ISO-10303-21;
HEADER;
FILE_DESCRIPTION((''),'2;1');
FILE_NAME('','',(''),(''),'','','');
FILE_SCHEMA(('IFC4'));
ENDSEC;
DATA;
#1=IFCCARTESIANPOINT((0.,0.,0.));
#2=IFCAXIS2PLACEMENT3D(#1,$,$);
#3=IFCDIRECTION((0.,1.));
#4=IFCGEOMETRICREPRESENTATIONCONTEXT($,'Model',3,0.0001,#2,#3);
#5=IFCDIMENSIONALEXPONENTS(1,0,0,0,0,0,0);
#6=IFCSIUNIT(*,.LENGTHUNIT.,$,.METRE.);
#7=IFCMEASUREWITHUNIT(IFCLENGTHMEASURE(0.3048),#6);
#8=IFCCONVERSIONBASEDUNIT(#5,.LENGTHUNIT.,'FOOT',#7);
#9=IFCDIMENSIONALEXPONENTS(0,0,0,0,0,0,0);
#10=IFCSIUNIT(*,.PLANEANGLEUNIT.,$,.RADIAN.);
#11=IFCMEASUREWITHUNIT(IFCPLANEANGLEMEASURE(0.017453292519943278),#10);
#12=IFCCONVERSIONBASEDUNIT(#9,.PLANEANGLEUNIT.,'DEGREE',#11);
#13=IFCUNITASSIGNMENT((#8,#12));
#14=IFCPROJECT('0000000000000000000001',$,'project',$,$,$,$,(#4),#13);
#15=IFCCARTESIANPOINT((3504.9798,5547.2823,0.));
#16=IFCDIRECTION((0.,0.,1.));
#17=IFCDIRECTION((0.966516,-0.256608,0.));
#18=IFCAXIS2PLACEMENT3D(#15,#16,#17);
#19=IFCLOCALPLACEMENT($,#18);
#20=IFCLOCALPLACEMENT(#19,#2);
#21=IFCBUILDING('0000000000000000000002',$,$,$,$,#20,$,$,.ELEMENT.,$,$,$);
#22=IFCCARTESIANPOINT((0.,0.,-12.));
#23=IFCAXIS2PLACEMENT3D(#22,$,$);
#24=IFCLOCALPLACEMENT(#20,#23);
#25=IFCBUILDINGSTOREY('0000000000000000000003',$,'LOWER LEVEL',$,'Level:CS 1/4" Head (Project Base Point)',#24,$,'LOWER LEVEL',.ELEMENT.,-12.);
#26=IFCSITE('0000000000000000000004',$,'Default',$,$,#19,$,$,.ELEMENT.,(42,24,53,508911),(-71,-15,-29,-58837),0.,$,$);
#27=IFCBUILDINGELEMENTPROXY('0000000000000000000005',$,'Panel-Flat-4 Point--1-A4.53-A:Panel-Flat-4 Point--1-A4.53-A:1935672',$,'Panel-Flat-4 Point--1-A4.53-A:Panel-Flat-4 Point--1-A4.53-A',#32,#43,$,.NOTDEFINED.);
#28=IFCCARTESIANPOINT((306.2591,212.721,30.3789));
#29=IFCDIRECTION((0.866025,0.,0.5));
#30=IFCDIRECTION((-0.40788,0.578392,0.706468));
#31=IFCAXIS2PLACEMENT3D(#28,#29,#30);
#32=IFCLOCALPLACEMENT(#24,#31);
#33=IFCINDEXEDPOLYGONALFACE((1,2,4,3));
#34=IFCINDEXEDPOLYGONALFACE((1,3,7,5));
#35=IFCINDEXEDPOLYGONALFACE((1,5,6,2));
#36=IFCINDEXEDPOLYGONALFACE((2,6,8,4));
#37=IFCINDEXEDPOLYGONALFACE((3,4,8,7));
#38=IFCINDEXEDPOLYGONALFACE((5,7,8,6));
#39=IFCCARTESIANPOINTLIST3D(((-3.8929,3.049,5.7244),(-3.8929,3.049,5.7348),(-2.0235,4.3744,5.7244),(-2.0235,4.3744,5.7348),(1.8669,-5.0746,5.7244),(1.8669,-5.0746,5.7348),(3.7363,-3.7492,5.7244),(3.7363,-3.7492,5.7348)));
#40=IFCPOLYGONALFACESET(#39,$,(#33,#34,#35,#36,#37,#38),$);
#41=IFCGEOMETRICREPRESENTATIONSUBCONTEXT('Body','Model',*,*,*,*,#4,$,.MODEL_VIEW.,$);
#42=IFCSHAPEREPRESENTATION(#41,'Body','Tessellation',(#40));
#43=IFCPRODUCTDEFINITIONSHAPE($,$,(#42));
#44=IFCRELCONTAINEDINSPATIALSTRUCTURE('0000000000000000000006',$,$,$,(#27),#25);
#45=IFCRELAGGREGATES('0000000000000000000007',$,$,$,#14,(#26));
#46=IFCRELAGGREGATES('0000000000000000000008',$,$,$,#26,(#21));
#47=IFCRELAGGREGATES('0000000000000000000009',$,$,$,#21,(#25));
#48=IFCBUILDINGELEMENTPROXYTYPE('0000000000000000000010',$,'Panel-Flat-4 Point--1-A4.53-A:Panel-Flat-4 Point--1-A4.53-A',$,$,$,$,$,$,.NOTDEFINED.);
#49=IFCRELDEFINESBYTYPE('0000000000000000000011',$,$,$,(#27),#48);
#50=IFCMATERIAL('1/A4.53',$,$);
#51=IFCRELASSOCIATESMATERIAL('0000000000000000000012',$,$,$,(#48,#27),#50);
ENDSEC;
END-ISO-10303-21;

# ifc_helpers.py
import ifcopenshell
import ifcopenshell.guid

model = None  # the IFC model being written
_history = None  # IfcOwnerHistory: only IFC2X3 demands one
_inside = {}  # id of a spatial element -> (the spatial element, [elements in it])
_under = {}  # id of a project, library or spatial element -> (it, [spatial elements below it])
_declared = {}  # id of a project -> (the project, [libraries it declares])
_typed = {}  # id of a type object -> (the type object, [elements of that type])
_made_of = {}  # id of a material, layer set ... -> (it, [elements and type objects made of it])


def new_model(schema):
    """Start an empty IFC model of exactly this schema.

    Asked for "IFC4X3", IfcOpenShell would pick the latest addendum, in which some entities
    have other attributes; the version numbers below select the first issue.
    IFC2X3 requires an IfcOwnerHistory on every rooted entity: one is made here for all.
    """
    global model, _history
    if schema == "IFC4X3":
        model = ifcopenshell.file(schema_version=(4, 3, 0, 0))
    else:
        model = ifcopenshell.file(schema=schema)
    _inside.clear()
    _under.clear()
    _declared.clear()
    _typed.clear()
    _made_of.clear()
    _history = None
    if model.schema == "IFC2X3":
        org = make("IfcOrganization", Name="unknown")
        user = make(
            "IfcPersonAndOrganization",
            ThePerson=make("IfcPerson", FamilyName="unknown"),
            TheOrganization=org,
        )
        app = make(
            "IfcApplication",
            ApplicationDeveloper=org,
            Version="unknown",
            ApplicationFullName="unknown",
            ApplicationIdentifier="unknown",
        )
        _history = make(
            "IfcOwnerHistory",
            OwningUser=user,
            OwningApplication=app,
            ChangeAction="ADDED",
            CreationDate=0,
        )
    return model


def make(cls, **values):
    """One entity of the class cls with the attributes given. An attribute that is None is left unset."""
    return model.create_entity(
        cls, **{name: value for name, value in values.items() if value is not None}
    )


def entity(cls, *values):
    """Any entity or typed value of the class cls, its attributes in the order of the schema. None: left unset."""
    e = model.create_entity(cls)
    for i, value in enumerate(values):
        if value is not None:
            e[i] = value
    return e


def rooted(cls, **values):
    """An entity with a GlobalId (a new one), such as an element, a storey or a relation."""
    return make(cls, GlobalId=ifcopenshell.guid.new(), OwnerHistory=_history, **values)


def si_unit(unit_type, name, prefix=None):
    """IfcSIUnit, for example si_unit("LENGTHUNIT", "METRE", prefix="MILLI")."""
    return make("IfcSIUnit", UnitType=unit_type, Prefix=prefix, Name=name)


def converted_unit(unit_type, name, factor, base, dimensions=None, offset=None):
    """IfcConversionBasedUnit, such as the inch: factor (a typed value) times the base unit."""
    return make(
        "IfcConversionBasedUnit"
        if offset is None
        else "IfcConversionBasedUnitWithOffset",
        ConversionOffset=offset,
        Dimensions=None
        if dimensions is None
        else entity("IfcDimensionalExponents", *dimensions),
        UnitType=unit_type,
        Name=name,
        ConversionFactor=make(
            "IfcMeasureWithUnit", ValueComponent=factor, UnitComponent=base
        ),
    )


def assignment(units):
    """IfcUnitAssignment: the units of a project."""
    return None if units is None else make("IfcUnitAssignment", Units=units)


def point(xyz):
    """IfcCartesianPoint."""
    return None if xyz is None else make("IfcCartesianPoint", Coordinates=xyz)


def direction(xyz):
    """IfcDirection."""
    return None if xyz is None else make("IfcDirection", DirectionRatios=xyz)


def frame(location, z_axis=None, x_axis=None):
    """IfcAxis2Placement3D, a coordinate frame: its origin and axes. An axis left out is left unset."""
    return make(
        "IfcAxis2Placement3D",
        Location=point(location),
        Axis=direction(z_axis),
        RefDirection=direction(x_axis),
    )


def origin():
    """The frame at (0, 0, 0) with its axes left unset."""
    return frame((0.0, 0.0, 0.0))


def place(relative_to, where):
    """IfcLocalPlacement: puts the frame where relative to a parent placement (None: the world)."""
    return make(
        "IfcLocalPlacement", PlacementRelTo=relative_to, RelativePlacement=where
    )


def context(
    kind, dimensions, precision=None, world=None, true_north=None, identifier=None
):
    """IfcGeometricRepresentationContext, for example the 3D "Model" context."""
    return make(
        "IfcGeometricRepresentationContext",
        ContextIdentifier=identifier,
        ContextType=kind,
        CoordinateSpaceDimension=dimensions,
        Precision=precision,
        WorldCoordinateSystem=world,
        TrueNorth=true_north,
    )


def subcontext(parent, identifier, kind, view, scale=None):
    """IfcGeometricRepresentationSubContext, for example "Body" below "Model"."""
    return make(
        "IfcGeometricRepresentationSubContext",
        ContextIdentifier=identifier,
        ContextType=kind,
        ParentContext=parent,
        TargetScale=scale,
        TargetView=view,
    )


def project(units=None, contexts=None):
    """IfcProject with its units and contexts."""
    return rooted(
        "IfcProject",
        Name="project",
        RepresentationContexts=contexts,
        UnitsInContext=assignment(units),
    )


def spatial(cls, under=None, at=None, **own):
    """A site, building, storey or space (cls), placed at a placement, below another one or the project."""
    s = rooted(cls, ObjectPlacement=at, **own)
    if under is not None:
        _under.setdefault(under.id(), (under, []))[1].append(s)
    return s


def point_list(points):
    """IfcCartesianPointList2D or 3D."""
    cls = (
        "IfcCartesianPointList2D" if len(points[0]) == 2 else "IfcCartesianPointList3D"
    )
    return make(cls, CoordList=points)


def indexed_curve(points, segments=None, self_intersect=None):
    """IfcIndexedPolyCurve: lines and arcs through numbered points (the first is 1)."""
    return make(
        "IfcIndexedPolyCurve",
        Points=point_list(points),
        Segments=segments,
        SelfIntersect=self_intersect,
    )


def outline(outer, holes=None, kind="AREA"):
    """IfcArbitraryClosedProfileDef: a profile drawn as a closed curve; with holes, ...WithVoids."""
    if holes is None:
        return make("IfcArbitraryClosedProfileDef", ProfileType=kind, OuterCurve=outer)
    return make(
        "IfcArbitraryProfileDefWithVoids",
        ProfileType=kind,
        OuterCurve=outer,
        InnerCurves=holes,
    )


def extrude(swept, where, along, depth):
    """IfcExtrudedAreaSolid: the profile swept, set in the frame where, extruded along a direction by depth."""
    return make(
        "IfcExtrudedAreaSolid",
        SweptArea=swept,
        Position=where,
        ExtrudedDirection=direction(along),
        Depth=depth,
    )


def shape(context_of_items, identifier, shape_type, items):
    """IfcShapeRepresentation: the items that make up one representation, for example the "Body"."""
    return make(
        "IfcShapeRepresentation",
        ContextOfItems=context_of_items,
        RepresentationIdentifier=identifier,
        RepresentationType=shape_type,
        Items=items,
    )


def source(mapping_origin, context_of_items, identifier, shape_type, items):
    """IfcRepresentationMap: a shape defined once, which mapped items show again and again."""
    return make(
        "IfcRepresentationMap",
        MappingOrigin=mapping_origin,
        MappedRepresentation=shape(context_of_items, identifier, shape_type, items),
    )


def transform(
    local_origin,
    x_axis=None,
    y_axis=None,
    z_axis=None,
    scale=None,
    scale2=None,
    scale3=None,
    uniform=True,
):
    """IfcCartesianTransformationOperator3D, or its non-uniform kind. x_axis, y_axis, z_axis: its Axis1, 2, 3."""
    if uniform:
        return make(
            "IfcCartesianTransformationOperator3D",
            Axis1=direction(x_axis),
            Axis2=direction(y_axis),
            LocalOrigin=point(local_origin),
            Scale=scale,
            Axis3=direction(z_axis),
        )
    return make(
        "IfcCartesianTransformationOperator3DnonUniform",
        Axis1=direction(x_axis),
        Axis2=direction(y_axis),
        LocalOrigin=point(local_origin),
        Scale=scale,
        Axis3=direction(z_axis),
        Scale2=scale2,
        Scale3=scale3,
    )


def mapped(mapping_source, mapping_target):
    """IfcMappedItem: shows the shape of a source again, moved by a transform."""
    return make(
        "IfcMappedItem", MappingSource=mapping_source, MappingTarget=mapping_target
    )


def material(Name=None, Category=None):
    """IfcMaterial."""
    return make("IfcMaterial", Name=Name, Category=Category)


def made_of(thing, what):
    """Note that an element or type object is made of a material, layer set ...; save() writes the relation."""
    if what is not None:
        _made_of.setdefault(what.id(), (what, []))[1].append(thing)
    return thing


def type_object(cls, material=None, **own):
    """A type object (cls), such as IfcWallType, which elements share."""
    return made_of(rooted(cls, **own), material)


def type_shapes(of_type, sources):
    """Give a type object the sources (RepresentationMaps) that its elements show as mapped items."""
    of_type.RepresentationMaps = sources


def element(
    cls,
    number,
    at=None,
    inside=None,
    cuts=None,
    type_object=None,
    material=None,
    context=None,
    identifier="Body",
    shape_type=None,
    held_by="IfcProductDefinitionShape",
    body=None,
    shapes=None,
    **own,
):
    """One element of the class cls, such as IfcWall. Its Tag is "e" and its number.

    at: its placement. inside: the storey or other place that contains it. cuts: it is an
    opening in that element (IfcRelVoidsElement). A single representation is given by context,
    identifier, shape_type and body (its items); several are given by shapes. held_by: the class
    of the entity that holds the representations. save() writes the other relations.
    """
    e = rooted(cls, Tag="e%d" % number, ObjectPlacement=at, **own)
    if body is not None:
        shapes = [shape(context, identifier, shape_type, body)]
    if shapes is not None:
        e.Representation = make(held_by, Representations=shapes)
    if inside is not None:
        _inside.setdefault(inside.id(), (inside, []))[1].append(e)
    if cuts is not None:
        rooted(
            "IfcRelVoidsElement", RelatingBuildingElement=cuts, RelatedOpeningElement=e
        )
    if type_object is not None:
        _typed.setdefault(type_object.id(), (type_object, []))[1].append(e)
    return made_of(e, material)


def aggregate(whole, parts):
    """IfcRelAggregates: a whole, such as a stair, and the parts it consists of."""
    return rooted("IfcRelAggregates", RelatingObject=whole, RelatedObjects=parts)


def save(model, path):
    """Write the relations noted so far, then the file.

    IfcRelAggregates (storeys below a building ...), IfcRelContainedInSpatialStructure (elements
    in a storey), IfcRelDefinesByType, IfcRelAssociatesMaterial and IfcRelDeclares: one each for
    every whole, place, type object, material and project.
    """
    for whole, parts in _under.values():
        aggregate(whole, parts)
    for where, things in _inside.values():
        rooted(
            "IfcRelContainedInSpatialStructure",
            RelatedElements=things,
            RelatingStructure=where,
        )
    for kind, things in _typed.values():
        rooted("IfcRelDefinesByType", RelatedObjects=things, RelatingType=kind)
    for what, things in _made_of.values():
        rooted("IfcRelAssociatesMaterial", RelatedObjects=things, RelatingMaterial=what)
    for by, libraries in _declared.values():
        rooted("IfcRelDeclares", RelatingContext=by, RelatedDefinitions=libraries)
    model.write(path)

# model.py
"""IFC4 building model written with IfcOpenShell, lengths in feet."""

from ifc_helpers import new_model, entity, si_unit, converted_unit, direction, frame, origin, place, context, subcontext, project, spatial, indexed_curve, outline, extrude, source, transform, mapped, material, type_object, type_shapes, element, save


model = new_model("IFC4")

# Units and contexts
model_context = context("Model", 3, precision=0.0001, world=origin(), true_north=direction((0.0, 1.0)))
body_context = subcontext(model_context, "Body", "Model", "MODEL_VIEW")
ifc_project = project(units=[converted_unit("LENGTHUNIT", "FOOT", entity("IfcLengthMeasure", 0.3048), si_unit("LENGTHUNIT", "METRE"), dimensions=[1, 0, 0, 0, 0, 0, 0]), converted_unit("PLANEANGLEUNIT", "DEGREE", entity("IfcPlaneAngleMeasure", 0.017453292519943278), si_unit("PLANEANGLEUNIT", "RADIAN"), dimensions=[0, 0, 0, 0, 0, 0, 0])], contexts=[model_context])

# Site, building, storey
site_placement = place(None, frame((3504.9798, 5547.2823, 0.0), z_axis=(0.0, 0.0, 1.0), x_axis=(0.966516, -0.256608, 0.0)))
site = spatial("IfcSite", under=ifc_project, at=site_placement, Name="Default", CompositionType="ELEMENT", RefLatitude=(42, 24, 53, 508911), RefLongitude=(-71, -15, -29, -58837), RefElevation=0.0)
building_placement = place(site_placement, origin())
building = spatial("IfcBuilding", under=site, at=building_placement, CompositionType="ELEMENT")
storey_placement = place(building_placement, frame((0.0, 0.0, -12.0)))
storey = spatial("IfcBuildingStorey", under=building, at=storey_placement, Name="LOWER LEVEL", ObjectType="Level:CS 1/4\" Head (Project Base Point)", LongName="LOWER LEVEL", CompositionType="ELEMENT", Elevation=-12.0)

# Building element proxy
ifc_material_1 = material(Name="1/A4.53")
building_element_proxy_type = type_object("IfcBuildingElementProxyType", Name="Panel-Flat-4 Point--1-A4.53-A:Panel-Flat-4 Point--1-A4.53-A", PredefinedType="NOTDEFINED", material=ifc_material_1)
shared_shape = source(origin(), body_context, "Body", "SweptSolid", [
    extrude(outline(indexed_curve([(-0.0052, -1.1458), (0.0052, -1.1458), (0.0052, 1.1458), (-0.0052, 1.1458), (-0.0052, -1.1458)], self_intersect=False)), frame((2.8016, -4.4119, 5.7296), z_axis=(-0.578392, 0.815759, 0.0), x_axis=(0.0, 0.0, 1.0)), (0.0, 0.0, 1.0), 9.9583),
])
type_shapes(building_element_proxy_type, [shared_shape])
proxy_placement = place(storey_placement, frame((306.2591, 212.721, 30.3789), z_axis=(0.866025, 0.0, 0.5), x_axis=(-0.40788, 0.578392, 0.706468)))
element("IfcBuildingElementProxy", 1, at=proxy_placement, inside=storey, type_object=building_element_proxy_type, material=ifc_material_1, Name="Panel-Flat-4 Point--1-A4.53-A:Panel-Flat-4 Point--1-A4.53-A:1935672", ObjectType="Panel-Flat-4 Point--1-A4.53-A:Panel-Flat-4 Point--1-A4.53-A", PredefinedType="NOTDEFINED", context=body_context, shape_type="MappedRepresentation", body=[
    mapped(shared_shape, transform((0.0, 0.0, 0.0), scale=1.0)),
])

save(model, "model.ifc")
